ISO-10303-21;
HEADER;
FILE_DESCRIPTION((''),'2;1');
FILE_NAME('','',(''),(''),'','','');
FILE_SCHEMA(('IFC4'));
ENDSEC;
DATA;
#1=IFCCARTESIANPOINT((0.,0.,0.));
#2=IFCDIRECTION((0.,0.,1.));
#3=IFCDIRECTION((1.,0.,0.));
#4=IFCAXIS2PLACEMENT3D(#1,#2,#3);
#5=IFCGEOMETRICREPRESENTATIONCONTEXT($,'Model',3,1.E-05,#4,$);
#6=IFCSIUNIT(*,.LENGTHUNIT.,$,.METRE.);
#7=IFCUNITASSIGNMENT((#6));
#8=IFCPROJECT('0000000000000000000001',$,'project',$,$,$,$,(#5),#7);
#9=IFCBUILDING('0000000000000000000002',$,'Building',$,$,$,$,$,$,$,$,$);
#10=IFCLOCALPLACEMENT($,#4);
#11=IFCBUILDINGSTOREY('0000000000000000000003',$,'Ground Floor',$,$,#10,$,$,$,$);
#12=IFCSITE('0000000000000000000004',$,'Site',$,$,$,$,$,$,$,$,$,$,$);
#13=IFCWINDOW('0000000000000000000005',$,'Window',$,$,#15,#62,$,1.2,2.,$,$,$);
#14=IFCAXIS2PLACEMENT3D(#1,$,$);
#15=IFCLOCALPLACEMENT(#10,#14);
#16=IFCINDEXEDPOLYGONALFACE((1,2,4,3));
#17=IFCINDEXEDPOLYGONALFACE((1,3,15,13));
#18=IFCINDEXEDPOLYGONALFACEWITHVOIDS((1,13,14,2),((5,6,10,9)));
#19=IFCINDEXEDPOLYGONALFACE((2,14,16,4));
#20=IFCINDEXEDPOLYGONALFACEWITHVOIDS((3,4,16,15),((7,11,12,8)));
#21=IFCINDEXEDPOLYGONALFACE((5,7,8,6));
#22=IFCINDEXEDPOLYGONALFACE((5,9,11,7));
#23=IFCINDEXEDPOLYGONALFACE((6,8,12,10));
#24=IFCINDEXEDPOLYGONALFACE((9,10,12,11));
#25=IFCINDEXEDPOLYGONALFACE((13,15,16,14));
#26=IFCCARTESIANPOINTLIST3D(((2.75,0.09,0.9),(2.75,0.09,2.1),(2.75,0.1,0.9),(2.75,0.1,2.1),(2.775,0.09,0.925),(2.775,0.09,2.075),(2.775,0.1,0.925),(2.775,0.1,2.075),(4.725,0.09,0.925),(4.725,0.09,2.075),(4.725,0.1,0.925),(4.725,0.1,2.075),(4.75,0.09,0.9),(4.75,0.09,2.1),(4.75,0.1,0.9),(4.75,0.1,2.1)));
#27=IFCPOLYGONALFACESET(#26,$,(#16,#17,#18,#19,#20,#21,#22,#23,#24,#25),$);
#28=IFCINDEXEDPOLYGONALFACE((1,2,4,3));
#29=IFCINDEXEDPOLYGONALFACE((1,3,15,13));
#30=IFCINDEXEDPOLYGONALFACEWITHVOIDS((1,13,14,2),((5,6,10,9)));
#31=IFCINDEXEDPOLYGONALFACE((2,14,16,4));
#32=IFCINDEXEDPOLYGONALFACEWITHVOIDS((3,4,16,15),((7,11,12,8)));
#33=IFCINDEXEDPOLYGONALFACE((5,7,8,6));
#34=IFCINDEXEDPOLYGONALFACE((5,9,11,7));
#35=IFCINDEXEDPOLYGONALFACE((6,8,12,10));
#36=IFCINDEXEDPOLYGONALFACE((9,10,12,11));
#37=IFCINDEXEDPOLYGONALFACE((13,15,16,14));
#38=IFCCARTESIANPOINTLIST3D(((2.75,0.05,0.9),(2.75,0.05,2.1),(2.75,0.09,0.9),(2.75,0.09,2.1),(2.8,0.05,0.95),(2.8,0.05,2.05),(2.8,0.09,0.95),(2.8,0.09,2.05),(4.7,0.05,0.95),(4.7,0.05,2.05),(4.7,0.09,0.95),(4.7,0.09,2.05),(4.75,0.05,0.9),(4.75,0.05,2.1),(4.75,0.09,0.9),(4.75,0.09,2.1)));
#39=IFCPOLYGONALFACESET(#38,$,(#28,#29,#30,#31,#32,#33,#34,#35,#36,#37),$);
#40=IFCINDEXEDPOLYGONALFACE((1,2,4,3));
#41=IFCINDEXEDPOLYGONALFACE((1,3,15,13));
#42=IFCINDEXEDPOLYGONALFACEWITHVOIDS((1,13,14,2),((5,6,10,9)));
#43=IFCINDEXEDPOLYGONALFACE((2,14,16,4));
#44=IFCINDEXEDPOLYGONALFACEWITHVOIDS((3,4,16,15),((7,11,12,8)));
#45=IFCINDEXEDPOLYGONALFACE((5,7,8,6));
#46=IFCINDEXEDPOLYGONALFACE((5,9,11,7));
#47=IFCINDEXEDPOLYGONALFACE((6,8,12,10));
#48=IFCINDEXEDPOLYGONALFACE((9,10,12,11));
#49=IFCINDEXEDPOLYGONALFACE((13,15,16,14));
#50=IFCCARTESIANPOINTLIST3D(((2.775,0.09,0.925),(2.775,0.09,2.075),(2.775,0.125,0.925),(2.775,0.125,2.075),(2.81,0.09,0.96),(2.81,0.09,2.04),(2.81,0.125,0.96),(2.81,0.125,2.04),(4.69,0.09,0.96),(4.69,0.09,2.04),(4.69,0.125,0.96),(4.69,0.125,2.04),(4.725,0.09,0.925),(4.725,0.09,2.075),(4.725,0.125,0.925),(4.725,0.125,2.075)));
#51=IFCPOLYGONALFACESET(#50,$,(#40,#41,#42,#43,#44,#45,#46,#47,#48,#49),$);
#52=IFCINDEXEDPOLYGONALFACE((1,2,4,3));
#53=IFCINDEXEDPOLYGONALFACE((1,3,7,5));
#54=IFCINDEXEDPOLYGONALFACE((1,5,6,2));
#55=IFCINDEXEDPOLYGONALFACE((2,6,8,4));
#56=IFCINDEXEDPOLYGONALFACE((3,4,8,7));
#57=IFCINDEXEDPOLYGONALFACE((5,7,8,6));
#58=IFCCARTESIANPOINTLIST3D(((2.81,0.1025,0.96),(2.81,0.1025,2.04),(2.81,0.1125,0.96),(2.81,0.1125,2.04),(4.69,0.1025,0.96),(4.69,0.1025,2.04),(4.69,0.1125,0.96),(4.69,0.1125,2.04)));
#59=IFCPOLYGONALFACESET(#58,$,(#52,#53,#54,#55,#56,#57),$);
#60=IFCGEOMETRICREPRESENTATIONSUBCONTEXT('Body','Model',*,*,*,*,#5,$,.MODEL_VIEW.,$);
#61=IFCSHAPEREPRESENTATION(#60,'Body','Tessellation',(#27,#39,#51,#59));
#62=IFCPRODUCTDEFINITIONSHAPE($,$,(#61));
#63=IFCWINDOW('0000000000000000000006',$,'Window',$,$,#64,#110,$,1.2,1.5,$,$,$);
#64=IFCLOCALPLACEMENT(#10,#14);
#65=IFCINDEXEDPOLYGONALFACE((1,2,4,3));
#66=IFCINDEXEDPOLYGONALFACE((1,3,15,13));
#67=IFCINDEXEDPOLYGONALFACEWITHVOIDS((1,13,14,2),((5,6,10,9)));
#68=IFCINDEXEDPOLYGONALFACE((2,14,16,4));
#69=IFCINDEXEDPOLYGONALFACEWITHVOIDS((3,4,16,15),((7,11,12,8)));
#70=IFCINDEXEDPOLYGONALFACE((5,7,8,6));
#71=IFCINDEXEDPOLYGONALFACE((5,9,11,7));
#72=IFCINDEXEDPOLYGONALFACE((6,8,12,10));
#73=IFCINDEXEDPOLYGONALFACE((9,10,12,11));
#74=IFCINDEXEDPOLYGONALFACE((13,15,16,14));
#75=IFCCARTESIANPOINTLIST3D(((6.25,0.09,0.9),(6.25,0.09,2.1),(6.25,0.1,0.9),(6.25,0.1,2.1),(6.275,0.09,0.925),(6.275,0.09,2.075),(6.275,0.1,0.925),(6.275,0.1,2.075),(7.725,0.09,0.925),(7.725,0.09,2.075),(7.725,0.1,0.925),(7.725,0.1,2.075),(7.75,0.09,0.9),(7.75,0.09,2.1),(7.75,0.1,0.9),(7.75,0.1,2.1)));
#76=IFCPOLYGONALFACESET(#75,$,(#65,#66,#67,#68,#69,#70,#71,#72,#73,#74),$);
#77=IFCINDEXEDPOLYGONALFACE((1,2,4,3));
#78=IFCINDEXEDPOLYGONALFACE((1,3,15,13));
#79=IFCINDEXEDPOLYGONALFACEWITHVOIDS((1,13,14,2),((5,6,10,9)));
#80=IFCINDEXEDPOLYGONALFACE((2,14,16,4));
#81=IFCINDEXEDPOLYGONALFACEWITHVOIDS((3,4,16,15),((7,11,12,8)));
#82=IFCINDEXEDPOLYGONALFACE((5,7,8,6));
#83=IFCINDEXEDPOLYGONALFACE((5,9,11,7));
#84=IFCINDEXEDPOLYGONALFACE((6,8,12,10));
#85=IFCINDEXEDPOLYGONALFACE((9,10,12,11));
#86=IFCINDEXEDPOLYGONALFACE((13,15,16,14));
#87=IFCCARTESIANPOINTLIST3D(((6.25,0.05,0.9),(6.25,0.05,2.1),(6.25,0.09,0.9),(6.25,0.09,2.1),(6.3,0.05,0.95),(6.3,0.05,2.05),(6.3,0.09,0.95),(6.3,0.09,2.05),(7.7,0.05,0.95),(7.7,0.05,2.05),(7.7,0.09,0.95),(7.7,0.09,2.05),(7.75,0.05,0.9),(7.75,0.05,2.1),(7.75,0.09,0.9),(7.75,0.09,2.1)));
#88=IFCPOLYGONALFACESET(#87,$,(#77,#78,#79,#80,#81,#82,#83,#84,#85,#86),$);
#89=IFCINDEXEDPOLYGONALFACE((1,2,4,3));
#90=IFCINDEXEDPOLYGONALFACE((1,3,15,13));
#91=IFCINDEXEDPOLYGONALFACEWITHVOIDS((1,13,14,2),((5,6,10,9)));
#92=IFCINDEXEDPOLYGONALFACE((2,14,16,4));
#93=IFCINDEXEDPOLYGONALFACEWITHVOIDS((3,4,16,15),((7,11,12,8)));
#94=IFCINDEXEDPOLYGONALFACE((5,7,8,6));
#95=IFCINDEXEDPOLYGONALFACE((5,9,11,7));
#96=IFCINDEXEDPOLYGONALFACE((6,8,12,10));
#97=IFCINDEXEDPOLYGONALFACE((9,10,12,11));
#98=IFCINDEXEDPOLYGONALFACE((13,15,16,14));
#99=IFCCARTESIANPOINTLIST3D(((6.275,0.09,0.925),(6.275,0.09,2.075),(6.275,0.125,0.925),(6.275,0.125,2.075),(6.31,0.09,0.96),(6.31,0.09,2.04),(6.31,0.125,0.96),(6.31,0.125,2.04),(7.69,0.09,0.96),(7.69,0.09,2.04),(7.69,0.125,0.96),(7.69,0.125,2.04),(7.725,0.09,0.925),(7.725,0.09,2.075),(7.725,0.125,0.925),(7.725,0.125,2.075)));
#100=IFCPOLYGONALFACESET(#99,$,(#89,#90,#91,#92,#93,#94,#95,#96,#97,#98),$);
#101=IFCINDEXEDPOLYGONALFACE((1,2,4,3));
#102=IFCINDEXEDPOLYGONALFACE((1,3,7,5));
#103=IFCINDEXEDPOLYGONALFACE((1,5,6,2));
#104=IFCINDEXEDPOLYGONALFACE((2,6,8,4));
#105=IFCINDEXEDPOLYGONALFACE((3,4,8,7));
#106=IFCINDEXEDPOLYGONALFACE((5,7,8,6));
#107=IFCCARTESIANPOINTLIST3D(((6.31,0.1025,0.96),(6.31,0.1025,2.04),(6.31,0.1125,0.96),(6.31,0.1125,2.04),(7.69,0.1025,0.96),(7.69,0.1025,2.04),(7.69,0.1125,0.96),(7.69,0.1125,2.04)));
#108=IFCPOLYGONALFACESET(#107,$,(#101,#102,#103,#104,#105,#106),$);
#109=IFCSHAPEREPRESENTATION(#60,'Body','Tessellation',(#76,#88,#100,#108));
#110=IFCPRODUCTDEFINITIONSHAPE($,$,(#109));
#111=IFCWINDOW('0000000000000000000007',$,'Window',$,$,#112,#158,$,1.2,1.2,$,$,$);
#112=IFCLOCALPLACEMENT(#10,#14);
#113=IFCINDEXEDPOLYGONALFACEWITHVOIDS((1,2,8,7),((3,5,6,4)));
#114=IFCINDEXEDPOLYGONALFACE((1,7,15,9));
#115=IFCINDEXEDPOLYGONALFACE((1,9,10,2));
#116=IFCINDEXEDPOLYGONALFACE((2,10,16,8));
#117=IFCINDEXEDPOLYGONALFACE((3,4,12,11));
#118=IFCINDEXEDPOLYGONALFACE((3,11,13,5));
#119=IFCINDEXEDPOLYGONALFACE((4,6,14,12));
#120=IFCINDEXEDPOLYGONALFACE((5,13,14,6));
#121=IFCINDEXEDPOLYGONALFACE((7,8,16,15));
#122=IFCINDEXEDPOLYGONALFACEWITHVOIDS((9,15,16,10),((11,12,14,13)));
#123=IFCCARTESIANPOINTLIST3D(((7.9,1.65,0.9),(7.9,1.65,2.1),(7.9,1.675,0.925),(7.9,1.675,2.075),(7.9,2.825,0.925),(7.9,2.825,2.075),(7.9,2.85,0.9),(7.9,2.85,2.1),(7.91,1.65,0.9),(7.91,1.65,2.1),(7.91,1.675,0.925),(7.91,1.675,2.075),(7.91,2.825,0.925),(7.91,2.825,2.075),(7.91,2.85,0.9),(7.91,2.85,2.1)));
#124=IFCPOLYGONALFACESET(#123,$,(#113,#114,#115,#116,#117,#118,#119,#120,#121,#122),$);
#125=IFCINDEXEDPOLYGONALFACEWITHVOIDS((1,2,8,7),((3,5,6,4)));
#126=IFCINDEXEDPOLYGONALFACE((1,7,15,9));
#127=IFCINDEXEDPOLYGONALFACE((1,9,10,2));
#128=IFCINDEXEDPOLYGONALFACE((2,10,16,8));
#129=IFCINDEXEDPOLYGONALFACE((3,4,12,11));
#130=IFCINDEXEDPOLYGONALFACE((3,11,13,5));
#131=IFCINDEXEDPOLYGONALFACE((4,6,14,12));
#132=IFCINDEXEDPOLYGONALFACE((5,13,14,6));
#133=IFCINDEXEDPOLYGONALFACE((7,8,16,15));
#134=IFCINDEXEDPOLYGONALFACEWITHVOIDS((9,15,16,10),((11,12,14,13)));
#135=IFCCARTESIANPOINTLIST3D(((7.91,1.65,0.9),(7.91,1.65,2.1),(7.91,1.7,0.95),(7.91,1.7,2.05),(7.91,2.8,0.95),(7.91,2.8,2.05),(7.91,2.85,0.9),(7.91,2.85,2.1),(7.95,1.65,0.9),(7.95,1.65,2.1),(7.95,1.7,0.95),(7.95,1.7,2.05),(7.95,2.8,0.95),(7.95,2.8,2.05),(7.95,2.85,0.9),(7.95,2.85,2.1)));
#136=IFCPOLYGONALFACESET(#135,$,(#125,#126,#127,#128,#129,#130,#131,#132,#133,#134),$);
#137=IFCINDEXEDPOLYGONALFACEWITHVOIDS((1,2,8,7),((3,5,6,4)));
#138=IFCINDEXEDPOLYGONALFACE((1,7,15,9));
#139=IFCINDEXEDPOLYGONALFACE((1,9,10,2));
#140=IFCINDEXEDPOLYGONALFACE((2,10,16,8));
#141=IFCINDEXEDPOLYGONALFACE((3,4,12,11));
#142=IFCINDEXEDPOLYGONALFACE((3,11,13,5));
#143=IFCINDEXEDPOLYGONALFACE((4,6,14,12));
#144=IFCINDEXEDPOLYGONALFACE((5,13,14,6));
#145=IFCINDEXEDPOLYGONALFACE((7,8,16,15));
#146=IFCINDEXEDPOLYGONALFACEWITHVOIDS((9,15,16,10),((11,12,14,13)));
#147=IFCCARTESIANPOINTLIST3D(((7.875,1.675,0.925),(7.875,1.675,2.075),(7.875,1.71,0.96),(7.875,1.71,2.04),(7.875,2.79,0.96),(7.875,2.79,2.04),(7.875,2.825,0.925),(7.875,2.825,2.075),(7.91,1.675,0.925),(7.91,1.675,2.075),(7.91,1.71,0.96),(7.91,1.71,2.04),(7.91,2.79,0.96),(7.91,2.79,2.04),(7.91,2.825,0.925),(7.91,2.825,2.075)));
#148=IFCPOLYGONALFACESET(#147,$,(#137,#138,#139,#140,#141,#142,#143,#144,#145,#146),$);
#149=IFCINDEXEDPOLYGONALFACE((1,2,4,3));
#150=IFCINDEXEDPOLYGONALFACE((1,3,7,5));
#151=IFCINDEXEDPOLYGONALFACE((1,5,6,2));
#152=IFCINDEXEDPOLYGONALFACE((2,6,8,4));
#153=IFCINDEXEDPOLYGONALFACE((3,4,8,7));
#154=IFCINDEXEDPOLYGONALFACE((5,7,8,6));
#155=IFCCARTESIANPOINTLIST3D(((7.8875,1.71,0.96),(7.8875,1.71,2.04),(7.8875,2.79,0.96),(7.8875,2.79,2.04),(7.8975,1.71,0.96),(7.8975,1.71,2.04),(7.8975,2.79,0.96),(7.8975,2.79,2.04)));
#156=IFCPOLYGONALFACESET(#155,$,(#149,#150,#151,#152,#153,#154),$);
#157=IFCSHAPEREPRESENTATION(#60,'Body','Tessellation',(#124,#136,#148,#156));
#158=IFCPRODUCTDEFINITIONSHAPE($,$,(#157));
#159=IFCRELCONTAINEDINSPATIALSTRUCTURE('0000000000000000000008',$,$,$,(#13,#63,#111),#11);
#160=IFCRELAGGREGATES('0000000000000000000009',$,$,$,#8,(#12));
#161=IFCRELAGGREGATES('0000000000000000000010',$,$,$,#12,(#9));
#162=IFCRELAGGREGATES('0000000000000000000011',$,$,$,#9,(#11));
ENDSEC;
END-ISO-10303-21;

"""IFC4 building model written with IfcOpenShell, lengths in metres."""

from ifc_helpers import new_model, si_unit, frame, origin_with_axes, place, context, subcontext, project, spatial, line, indexed_curve, outline, extrude, element, save


model = new_model("IFC4")

# Units and contexts
model_context = context("Model", 3, precision=1e-05, world=origin_with_axes())
body_context = subcontext(model_context, "Body", "Model", "MODEL_VIEW")
ifc_project = project(units=[si_unit("LENGTHUNIT", "METRE")], contexts=[model_context])

# Site, building, storey
site = spatial("IfcSite", under=ifc_project, Name="Site")
building = spatial("IfcBuilding", under=site, Name="Building")
storey_placement = place(None, origin_with_axes())
storey = spatial("IfcBuildingStorey", under=building, at=storey_placement, Name="Ground Floor")

# Windows
window_1_placement = place(storey_placement, frame((2.75, 0.0, 0.9), z_axis=(0.0, 0.0, 1.0), x_axis=(1.0, 0.0, 0.0)))
element("IfcWindow", 1, at=window_1_placement, inside=storey, Name="Window", OverallHeight=1.2, OverallWidth=2.0, context=body_context, shape_type="SweptSolid", body=[
    extrude(outline(indexed_curve([(0.0, 0.0), (2.0, 0.0), (2.0, 1.2), (0.0, 1.2)], segments=[line(1, 2, 3, 4, 1)]), holes=[indexed_curve([(0.025, 0.025), (1.975, 0.025), (1.975, 1.175), (0.025, 1.175)], segments=[line(1, 2, 3, 4, 1)])]), frame((0.0, 0.09, 0.0), z_axis=(0.0, -1.0, 0.0), x_axis=(1.0, 0.0, 0.0)), (0.0, 0.0, -1.0), 0.01),
    extrude(outline(indexed_curve([(0.0, 0.0), (2.0, 0.0), (2.0, 1.2), (0.0, 1.2)], segments=[line(1, 2, 3, 4, 1)]), holes=[indexed_curve([(0.05, 0.05), (1.95, 0.05), (1.95, 1.15), (0.05, 1.15)], segments=[line(1, 2, 3, 4, 1)])]), frame((0.0, 0.05, 0.0), z_axis=(0.0, -1.0, 0.0), x_axis=(1.0, 0.0, 0.0)), (0.0, 0.0, -1.0), 0.04),
    extrude(outline(indexed_curve([(0.0, 0.0), (1.95, 0.0), (1.95, 1.15), (0.0, 1.15)], segments=[line(1, 2, 3, 4, 1)]), holes=[indexed_curve([(0.035, 0.035), (1.915, 0.035), (1.915, 1.115), (0.035, 1.115)], segments=[line(1, 2, 3, 4, 1)])]), frame((0.025, 0.09, 0.025), z_axis=(0.0, -1.0, 0.0), x_axis=(1.0, 0.0, 0.0)), (0.0, 0.0, -1.0), 0.035),
    extrude(outline(indexed_curve([(0.035, 0.035), (1.915, 0.035), (1.915, 1.115), (0.035, 1.115)], segments=[line(1, 2, 3, 4, 1)])), frame((0.025, 0.1025, 0.025), z_axis=(0.0, -1.0, 0.0), x_axis=(1.0, 0.0, 0.0)), (0.0, 0.0, -1.0), 0.01),
])
window_2_placement = place(storey_placement, frame((6.25, 0.0, 0.9), z_axis=(0.0, 0.0, 1.0), x_axis=(1.0, 0.0, 0.0)))
element("IfcWindow", 2, at=window_2_placement, inside=storey, Name="Window", OverallHeight=1.2, OverallWidth=1.5, context=body_context, shape_type="SweptSolid", body=[
    extrude(outline(indexed_curve([(0.0, 0.0), (1.5, 0.0), (1.5, 1.2), (0.0, 1.2)], segments=[line(1, 2, 3, 4, 1)]), holes=[indexed_curve([(0.025, 0.025), (1.475, 0.025), (1.475, 1.175), (0.025, 1.175)], segments=[line(1, 2, 3, 4, 1)])]), frame((0.0, 0.09, 0.0), z_axis=(0.0, -1.0, 0.0), x_axis=(1.0, 0.0, 0.0)), (0.0, 0.0, -1.0), 0.01),
    extrude(outline(indexed_curve([(0.0, 0.0), (1.5, 0.0), (1.5, 1.2), (0.0, 1.2)], segments=[line(1, 2, 3, 4, 1)]), holes=[indexed_curve([(0.05, 0.05), (1.45, 0.05), (1.45, 1.15), (0.05, 1.15)], segments=[line(1, 2, 3, 4, 1)])]), frame((0.0, 0.05, 0.0), z_axis=(0.0, -1.0, 0.0), x_axis=(1.0, 0.0, 0.0)), (0.0, 0.0, -1.0), 0.04),
    extrude(outline(indexed_curve([(0.0, 0.0), (1.45, 0.0), (1.45, 1.15), (0.0, 1.15)], segments=[line(1, 2, 3, 4, 1)]), holes=[indexed_curve([(0.035, 0.035), (1.415, 0.035), (1.415, 1.115), (0.035, 1.115)], segments=[line(1, 2, 3, 4, 1)])]), frame((0.025, 0.09, 0.025), z_axis=(0.0, -1.0, 0.0), x_axis=(1.0, 0.0, 0.0)), (0.0, 0.0, -1.0), 0.035),
    extrude(outline(indexed_curve([(0.035, 0.035), (1.415, 0.035), (1.415, 1.115), (0.035, 1.115)], segments=[line(1, 2, 3, 4, 1)])), frame((0.025, 0.1025, 0.025), z_axis=(0.0, -1.0, 0.0), x_axis=(1.0, 0.0, 0.0)), (0.0, 0.0, -1.0), 0.01),
])
window_3_placement = place(storey_placement, frame((8.0, 1.65, 0.9), z_axis=(0.0, 0.0, 1.0), x_axis=(0.0, 1.0, 0.0)))
element("IfcWindow", 3, at=window_3_placement, inside=storey, Name="Window", OverallHeight=1.2, OverallWidth=1.2, context=body_context, shape_type="SweptSolid", body=[
    extrude(outline(indexed_curve([(0.0, 0.0), (1.2, 0.0), (1.2, 1.2), (0.0, 1.2)], segments=[line(1, 2, 3, 4, 1)]), holes=[indexed_curve([(0.025, 0.025), (1.175, 0.025), (1.175, 1.175), (0.025, 1.175)], segments=[line(1, 2, 3, 4, 1)])]), frame((0.0, 0.09, 0.0), z_axis=(0.0, -1.0, 0.0), x_axis=(1.0, 0.0, 0.0)), (0.0, 0.0, -1.0), 0.01),
    extrude(outline(indexed_curve([(0.0, 0.0), (1.2, 0.0), (1.2, 1.2), (0.0, 1.2)], segments=[line(1, 2, 3, 4, 1)]), holes=[indexed_curve([(0.05, 0.05), (1.15, 0.05), (1.15, 1.15), (0.05, 1.15)], segments=[line(1, 2, 3, 4, 1)])]), frame((0.0, 0.05, 0.0), z_axis=(0.0, -1.0, 0.0), x_axis=(1.0, 0.0, 0.0)), (0.0, 0.0, -1.0), 0.04),
    extrude(outline(indexed_curve([(0.0, 0.0), (1.15, 0.0), (1.15, 1.15), (0.0, 1.15)], segments=[line(1, 2, 3, 4, 1)]), holes=[indexed_curve([(0.035, 0.035), (1.115, 0.035), (1.115, 1.115), (0.035, 1.115)], segments=[line(1, 2, 3, 4, 1)])]), frame((0.025, 0.09, 0.025), z_axis=(0.0, -1.0, 0.0), x_axis=(1.0, 0.0, 0.0)), (0.0, 0.0, -1.0), 0.035),
    extrude(outline(indexed_curve([(0.035, 0.035), (1.115, 0.035), (1.115, 1.115), (0.035, 1.115)], segments=[line(1, 2, 3, 4, 1)])), frame((0.025, 0.1025, 0.025), z_axis=(0.0, -1.0, 0.0), x_axis=(1.0, 0.0, 0.0)), (0.0, 0.0, -1.0), 0.01),
])

save(model, "model.ifc")
